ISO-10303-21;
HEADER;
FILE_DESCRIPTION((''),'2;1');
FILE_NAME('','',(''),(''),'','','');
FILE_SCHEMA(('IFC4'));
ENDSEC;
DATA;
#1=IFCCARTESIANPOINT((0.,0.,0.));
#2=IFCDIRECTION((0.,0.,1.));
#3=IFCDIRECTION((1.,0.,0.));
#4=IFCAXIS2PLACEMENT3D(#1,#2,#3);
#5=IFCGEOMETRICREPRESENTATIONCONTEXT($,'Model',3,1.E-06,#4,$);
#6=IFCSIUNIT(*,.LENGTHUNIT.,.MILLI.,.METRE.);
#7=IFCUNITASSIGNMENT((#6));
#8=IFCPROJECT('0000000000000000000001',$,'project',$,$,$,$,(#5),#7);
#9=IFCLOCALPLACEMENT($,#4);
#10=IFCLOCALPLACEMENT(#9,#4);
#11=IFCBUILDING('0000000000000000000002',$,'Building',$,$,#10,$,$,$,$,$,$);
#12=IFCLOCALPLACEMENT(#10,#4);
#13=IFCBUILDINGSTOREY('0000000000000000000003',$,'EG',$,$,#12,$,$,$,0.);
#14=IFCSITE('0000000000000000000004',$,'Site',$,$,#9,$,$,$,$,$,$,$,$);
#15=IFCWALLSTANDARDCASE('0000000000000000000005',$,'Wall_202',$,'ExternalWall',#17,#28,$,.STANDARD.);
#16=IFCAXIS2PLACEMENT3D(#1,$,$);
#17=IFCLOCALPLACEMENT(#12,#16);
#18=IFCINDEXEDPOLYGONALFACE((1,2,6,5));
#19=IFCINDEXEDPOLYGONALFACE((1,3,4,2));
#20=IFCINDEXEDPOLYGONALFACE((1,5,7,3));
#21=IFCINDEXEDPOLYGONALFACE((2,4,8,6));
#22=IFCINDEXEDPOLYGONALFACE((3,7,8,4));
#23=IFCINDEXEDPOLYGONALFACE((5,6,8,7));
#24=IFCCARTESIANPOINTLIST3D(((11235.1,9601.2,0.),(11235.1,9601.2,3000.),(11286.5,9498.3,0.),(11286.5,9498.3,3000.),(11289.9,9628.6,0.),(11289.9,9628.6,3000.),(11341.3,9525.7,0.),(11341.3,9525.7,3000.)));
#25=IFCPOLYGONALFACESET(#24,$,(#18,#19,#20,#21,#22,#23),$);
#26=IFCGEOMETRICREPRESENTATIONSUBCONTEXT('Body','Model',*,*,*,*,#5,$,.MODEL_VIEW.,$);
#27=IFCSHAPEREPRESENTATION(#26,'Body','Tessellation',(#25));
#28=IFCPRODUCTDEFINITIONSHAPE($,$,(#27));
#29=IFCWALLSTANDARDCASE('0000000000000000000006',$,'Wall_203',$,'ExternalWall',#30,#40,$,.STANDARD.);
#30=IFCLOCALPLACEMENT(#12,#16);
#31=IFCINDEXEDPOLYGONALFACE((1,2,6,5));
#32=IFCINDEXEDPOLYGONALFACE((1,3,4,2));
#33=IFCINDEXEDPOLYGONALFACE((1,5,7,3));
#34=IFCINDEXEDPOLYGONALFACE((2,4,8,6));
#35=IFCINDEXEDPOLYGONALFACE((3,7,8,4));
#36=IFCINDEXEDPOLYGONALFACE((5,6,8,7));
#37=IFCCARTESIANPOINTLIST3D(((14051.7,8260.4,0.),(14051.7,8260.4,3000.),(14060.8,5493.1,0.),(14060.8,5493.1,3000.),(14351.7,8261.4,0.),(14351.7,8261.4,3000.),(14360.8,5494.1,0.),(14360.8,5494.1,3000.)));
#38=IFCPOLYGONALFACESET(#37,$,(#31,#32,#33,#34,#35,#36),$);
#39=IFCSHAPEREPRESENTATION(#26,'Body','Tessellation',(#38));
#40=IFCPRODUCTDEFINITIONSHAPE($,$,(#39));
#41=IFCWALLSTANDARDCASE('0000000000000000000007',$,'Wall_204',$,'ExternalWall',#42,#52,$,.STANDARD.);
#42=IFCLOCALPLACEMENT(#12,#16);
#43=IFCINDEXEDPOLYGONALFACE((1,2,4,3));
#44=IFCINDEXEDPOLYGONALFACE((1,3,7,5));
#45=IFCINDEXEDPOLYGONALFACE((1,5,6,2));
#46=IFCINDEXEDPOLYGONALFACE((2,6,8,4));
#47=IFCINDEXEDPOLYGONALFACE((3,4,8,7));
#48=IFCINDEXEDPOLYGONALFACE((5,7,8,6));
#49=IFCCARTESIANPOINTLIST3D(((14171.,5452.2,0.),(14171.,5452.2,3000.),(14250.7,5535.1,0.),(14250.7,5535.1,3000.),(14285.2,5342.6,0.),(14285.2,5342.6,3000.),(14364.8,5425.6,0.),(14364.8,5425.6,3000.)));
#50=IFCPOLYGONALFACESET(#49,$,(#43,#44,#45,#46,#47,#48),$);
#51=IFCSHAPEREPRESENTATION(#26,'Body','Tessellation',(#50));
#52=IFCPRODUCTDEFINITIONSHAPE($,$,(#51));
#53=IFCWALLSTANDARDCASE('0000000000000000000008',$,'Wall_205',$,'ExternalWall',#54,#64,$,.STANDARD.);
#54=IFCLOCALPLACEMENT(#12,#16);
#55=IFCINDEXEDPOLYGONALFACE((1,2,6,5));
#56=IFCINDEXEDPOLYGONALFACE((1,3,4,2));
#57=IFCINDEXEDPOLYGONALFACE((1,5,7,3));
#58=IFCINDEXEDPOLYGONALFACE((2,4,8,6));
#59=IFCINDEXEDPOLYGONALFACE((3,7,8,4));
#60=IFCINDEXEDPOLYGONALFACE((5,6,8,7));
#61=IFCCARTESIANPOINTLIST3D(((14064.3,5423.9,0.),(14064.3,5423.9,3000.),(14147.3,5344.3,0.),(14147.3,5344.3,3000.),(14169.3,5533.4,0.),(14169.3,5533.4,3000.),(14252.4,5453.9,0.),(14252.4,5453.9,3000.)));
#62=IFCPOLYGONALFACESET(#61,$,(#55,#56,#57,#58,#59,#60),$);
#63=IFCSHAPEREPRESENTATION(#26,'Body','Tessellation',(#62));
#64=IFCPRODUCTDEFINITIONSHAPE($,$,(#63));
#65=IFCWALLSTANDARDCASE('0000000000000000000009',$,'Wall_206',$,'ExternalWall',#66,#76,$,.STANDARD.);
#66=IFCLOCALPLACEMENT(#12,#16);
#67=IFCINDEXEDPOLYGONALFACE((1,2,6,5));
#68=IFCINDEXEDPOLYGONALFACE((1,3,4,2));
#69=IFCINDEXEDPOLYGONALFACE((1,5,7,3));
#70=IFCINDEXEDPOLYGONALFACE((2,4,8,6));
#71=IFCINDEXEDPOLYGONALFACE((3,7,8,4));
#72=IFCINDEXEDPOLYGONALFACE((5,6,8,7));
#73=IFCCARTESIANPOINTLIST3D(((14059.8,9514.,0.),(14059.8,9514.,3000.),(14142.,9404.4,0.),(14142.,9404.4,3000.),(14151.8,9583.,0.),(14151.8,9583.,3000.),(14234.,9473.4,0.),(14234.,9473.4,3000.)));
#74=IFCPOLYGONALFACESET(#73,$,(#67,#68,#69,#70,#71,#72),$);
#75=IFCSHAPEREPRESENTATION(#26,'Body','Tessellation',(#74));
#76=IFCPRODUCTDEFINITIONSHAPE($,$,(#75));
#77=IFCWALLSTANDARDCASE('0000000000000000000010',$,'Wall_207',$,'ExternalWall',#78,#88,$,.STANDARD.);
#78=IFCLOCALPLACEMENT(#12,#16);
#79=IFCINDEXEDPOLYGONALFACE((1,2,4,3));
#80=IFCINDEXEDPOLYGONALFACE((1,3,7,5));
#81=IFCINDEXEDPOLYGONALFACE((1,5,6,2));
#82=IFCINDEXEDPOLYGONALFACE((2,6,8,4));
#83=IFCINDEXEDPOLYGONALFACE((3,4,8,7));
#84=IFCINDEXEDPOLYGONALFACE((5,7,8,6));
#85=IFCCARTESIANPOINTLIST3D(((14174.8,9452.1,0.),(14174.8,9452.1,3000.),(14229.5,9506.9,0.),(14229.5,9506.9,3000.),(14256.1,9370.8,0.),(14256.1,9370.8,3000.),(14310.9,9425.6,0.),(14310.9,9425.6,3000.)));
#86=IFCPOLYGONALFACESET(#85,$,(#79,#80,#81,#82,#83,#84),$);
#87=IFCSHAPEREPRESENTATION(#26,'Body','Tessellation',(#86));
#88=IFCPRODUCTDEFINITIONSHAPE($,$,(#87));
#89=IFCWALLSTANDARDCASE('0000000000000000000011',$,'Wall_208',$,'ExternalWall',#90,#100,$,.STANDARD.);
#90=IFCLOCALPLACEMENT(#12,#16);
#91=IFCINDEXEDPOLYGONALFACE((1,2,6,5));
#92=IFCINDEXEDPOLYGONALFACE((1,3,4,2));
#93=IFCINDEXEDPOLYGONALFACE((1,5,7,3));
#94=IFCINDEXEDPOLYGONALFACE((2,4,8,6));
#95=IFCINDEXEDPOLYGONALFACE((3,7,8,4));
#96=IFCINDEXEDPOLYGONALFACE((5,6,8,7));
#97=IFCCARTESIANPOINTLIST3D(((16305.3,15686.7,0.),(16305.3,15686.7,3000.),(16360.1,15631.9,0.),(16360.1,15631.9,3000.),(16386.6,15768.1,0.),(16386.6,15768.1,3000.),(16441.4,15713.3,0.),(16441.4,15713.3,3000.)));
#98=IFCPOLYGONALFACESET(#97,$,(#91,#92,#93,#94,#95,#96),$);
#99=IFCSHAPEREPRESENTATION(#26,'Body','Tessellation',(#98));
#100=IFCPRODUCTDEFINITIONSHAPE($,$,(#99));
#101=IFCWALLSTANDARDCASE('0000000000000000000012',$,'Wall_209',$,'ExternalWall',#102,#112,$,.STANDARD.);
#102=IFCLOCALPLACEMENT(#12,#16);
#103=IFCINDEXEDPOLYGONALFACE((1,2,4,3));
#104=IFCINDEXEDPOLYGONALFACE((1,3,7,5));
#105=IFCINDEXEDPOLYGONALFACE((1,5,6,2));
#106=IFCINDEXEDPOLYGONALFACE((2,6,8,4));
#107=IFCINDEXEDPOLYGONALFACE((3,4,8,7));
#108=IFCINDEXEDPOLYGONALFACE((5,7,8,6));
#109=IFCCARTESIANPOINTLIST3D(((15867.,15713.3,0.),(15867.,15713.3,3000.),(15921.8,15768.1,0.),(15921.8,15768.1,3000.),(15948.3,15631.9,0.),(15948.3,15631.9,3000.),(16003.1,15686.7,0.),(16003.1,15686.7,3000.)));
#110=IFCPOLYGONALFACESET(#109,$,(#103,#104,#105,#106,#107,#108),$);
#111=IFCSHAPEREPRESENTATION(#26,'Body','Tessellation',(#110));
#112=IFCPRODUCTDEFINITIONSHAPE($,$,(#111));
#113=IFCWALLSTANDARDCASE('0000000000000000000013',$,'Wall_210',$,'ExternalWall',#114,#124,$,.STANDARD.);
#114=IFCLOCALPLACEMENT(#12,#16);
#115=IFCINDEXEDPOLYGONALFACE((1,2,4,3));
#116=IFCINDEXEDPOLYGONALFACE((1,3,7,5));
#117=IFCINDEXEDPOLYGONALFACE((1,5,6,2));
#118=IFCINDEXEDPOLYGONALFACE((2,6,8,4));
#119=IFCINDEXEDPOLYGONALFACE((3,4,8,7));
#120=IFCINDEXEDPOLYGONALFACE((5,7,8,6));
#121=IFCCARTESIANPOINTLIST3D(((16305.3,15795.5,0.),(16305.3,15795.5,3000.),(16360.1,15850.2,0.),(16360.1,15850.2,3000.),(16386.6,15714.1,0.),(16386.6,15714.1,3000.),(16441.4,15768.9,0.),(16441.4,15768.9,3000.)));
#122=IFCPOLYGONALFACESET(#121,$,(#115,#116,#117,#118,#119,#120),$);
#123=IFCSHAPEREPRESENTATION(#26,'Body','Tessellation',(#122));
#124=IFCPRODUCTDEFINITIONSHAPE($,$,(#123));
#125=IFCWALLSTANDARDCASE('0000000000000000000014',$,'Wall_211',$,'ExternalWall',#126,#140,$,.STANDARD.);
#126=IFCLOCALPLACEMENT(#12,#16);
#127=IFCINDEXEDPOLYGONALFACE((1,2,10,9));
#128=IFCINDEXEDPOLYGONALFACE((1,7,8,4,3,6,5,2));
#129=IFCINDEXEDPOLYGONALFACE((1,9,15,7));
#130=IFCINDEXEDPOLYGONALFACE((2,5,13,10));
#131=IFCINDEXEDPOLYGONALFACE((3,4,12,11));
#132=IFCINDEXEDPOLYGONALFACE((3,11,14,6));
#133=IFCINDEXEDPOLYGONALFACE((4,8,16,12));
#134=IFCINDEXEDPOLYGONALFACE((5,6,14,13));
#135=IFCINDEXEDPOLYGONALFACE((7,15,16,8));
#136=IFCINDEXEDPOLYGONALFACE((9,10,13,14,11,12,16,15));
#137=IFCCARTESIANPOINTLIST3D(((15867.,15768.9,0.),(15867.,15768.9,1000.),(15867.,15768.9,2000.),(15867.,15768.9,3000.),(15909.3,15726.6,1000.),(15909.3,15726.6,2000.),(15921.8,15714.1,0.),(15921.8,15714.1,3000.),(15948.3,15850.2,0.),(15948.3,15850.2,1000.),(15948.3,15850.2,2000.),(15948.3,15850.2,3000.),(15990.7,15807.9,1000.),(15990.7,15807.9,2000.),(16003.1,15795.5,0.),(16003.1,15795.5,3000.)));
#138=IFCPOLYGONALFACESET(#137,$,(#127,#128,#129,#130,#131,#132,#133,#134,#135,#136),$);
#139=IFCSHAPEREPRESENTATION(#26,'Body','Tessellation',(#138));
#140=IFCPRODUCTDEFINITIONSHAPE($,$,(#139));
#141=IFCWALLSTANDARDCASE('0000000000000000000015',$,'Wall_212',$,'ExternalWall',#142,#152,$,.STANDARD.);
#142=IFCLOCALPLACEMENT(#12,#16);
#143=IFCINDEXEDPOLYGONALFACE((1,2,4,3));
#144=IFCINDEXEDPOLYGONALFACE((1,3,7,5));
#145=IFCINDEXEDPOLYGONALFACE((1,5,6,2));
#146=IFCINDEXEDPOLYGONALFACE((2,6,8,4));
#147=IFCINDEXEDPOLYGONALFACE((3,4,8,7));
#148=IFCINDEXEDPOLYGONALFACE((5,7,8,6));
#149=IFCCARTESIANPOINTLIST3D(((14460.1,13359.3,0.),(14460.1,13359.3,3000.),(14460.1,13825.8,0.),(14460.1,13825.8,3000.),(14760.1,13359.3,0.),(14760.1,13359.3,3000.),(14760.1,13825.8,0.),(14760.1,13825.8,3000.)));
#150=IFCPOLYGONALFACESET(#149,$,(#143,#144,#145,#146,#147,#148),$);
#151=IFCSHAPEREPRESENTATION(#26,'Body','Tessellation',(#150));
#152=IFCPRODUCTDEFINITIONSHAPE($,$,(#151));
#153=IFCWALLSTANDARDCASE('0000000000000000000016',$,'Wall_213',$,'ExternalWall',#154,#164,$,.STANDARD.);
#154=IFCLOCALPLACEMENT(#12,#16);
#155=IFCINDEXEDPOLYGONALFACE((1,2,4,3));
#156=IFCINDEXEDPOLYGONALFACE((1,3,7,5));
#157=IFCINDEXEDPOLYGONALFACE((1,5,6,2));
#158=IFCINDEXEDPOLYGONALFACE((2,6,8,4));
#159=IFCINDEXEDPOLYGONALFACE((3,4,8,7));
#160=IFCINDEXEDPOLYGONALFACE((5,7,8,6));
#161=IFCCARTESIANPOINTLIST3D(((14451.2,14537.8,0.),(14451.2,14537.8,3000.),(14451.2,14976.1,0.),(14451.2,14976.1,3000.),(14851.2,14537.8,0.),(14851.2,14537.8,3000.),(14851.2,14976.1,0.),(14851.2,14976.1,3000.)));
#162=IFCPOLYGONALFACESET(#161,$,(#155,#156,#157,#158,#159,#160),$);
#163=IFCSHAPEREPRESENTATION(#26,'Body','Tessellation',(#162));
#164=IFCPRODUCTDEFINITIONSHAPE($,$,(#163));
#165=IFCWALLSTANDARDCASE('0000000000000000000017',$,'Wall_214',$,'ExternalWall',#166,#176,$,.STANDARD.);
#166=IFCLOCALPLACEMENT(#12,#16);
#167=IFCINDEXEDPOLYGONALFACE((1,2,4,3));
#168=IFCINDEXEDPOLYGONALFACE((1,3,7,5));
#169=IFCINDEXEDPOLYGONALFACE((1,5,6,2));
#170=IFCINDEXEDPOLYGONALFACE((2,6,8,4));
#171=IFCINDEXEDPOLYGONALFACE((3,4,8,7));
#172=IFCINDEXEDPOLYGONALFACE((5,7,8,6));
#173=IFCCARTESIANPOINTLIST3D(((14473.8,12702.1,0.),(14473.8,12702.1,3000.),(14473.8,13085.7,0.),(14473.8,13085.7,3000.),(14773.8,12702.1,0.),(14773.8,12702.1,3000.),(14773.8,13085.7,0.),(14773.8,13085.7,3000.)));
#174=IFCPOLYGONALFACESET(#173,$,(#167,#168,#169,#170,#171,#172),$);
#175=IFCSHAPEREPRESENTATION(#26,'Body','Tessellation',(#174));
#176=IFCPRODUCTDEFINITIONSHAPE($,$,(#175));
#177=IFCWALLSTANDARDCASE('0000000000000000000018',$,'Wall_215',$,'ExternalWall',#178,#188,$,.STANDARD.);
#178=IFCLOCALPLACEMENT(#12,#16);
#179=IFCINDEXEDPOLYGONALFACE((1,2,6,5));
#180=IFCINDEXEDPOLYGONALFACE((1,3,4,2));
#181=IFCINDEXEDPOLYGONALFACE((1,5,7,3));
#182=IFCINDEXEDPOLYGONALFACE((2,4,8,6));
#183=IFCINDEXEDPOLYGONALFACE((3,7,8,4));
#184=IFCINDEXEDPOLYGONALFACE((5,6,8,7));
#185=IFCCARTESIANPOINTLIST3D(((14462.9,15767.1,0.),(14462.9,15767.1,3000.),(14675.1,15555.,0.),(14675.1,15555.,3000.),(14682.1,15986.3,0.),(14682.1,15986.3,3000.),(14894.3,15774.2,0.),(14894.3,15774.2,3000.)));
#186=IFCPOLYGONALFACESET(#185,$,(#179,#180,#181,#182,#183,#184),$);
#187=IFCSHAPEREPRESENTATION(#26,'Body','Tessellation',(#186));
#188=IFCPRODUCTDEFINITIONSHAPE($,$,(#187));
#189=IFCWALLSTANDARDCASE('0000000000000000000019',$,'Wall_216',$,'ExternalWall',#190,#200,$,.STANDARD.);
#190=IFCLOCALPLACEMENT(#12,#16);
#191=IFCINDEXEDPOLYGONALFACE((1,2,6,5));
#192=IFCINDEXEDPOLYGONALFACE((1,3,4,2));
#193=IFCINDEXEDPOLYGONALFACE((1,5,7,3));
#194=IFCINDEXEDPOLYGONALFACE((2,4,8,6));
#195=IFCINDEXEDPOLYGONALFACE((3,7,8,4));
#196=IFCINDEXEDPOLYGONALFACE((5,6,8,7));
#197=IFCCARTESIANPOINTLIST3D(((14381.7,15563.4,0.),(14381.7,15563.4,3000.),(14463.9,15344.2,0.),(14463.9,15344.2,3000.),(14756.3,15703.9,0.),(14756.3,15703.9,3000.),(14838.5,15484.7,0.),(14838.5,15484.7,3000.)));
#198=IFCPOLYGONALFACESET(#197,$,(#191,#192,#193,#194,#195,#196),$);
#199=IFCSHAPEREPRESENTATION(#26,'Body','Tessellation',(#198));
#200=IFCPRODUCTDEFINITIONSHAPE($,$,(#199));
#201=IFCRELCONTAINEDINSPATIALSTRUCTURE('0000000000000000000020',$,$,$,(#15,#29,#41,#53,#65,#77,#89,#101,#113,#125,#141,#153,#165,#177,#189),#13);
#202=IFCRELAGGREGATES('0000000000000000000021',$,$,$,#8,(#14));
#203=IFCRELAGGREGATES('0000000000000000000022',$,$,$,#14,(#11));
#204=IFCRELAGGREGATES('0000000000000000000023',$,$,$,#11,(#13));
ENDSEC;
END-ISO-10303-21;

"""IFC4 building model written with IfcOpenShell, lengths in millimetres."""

from ifc_helpers import new_model, si_unit, frame, origin_with_axes, place, context, subcontext, project, spatial, rectangle, extrude, element, save


model = new_model("IFC4")

# Units and contexts
model_context = context("Model", 3, precision=1e-06, world=origin_with_axes())
body_context = subcontext(model_context, "Body", "Model", "MODEL_VIEW")
ifc_project = project(units=[si_unit("LENGTHUNIT", "METRE", prefix="MILLI")], contexts=[model_context])

# Site, building, storey
site_placement = place(None, origin_with_axes())
site = spatial("IfcSite", under=ifc_project, at=site_placement, Name="Site")
building_placement = place(site_placement, origin_with_axes())
building = spatial("IfcBuilding", under=site, at=building_placement, Name="Building")
storey_placement = place(building_placement, origin_with_axes())
storey = spatial("IfcBuildingStorey", under=building, at=storey_placement, Name="EG", Elevation=0.0)

# Walls
wall_1_placement = place(storey_placement, origin_with_axes())
element("IfcWallStandardCase", 1, at=wall_1_placement, inside=storey, Name="Wall_202", ObjectType="ExternalWall", PredefinedType="STANDARD", context=body_context, shape_type="SweptSolid", body=[
    extrude(rectangle(XDim=61.3, YDim=115.0), frame((11288.2, 9563.4, 0.0), z_axis=(0.0, 0.0, 1.0), x_axis=(0.894427, 0.447214, 0.0)), (0.0, 0.0, 1.0), 3000.0),
])
wall_2_placement = place(storey_placement, origin_with_axes())
element("IfcWallStandardCase", 2, at=wall_2_placement, inside=storey, Name="Wall_203", ObjectType="ExternalWall", PredefinedType="STANDARD", context=body_context, shape_type="SweptSolid", body=[
    extrude(rectangle(XDim=2767.2, YDim=300.0), frame((14206.3, 6877.2, 0.0), z_axis=(0.0, 0.0, 1.0), x_axis=(0.0033, -0.999995, 0.0)), (0.0, 0.0, 1.0), 3000.0),
])
wall_3_placement = place(storey_placement, origin_with_axes())
element("IfcWallStandardCase", 3, at=wall_3_placement, inside=storey, Name="Wall_204", ObjectType="ExternalWall", PredefinedType="STANDARD", context=body_context, shape_type="SweptSolid", body=[
    extrude(rectangle(XDim=158.2, YDim=115.0), frame((14267.9, 5438.9, 0.0), z_axis=(0.0, 0.0, 1.0), x_axis=(0.721459, -0.692457, 0.0)), (0.0, 0.0, 1.0), 3000.0),
])
wall_4_placement = place(storey_placement, origin_with_axes())
element("IfcWallStandardCase", 4, at=wall_4_placement, inside=storey, Name="Wall_205", ObjectType="ExternalWall", PredefinedType="STANDARD", context=body_context, shape_type="SweptSolid", body=[
    extrude(rectangle(XDim=151.8, YDim=115.0), frame((14158.3, 5438.9, 0.0), z_axis=(0.0, 0.0, 1.0), x_axis=(-0.69198, -0.721917, 0.0)), (0.0, 0.0, 1.0), 3000.0),
])
wall_5_placement = place(storey_placement, origin_with_axes())
element("IfcWallStandardCase", 5, at=wall_5_placement, inside=storey, Name="Wall_206", ObjectType="ExternalWall", PredefinedType="STANDARD", context=body_context, shape_type="SweptSolid", body=[
    extrude(rectangle(XDim=137.0, YDim=115.0), frame((14146.9, 9493.7, 0.0), z_axis=(0.0, 0.0, 1.0), x_axis=(-0.6, 0.8, 0.0)), (0.0, 0.0, 1.0), 3000.0),
])
wall_6_placement = place(storey_placement, origin_with_axes())
element("IfcWallStandardCase", 6, at=wall_6_placement, inside=storey, Name="Wall_207", ObjectType="ExternalWall", PredefinedType="STANDARD", context=body_context, shape_type="SweptSolid", body=[
    extrude(rectangle(XDim=77.5, YDim=115.0), frame((14242.8, 9438.9, 0.0), z_axis=(0.0, 0.0, 1.0), x_axis=(0.707107, 0.707107, 0.0)), (0.0, 0.0, 1.0), 3000.0),
])
wall_7_placement = place(storey_placement, origin_with_axes())
element("IfcWallStandardCase", 7, at=wall_7_placement, inside=storey, Name="Wall_208", ObjectType="ExternalWall", PredefinedType="STANDARD", context=body_context, shape_type="SweptSolid", body=[
    extrude(rectangle(XDim=77.5, YDim=115.0), frame((16373.4, 15700.0, 0.0), z_axis=(0.0, 0.0, 1.0), x_axis=(0.707107, -0.707107, 0.0)), (0.0, 0.0, 1.0), 3000.0),
])
wall_8_placement = place(storey_placement, origin_with_axes())
element("IfcWallStandardCase", 8, at=wall_8_placement, inside=storey, Name="Wall_209", ObjectType="ExternalWall", PredefinedType="STANDARD", context=body_context, shape_type="SweptSolid", body=[
    extrude(rectangle(XDim=77.5, YDim=115.0), frame((15935.0, 15700.0, 0.0), z_axis=(0.0, 0.0, 1.0), x_axis=(-0.707107, -0.707107, 0.0)), (0.0, 0.0, 1.0), 3000.0),
])
wall_9_placement = place(storey_placement, origin_with_axes())
element("IfcWallStandardCase", 9, at=wall_9_placement, inside=storey, Name="Wall_210", ObjectType="ExternalWall", PredefinedType="STANDARD", context=body_context, shape_type="SweptSolid", body=[
    extrude(rectangle(XDim=77.5, YDim=115.0), frame((16373.4, 15782.2, 0.0), z_axis=(0.0, 0.0, 1.0), x_axis=(-0.707107, -0.707107, 0.0)), (0.0, 0.0, 1.0), 3000.0),
])

# Wall, opening
wall_10_placement = place(storey_placement, origin_with_axes())
wall_10 = element("IfcWallStandardCase", 10, at=wall_10_placement, inside=storey, Name="Wall_211", ObjectType="ExternalWall", PredefinedType="STANDARD", context=body_context, shape_type="SweptSolid", body=[
    extrude(rectangle(XDim=77.5, YDim=115.0), frame((15935.0, 15782.2, 0.0), z_axis=(0.0, 0.0, 1.0), x_axis=(-0.707107, 0.707107, 0.0)), (0.0, 0.0, 1.0), 3000.0),
])
opening_placement = place(wall_10_placement, origin_with_axes())
element("IfcOpeningElement", 11, at=opening_placement, inside=storey, cuts=wall_10, context=body_context, shape_type="SweptSolid", body=[
    extrude(rectangle(XDim=830.9, YDim=115.0), frame((15656.2, 16061.0, 1000.0), z_axis=(0.0, 0.0, 1.0), x_axis=(-0.707107, 0.707107, 0.0)), (0.0, 0.0, 1.0), 1000.0),
])

# Walls
wall_11_placement = place(storey_placement, origin_with_axes())
element("IfcWallStandardCase", 12, at=wall_11_placement, inside=storey, Name="Wall_212", ObjectType="ExternalWall", PredefinedType="STANDARD", context=body_context, shape_type="SweptSolid", body=[
    extrude(rectangle(XDim=466.6, YDim=300.0), frame((14610.1, 13592.6, 0.0), z_axis=(0.0, 0.0, 1.0), x_axis=(0.0, 1.0, 0.0)), (0.0, 0.0, 1.0), 3000.0),
])
wall_12_placement = place(storey_placement, origin_with_axes())
element("IfcWallStandardCase", 13, at=wall_12_placement, inside=storey, Name="Wall_213", ObjectType="ExternalWall", PredefinedType="STANDARD", context=body_context, shape_type="SweptSolid", body=[
    extrude(rectangle(XDim=438.4, YDim=400.0), frame((14651.2, 14756.9, 0.0), z_axis=(0.0, 0.0, 1.0), x_axis=(0.0, 1.0, 0.0)), (0.0, 0.0, 1.0), 3000.0),
])
wall_13_placement = place(storey_placement, origin_with_axes())
element("IfcWallStandardCase", 14, at=wall_13_placement, inside=storey, Name="Wall_214", ObjectType="ExternalWall", PredefinedType="STANDARD", context=body_context, shape_type="SweptSolid", body=[
    extrude(rectangle(XDim=383.6, YDim=300.0), frame((14623.8, 12893.9, 0.0), z_axis=(0.0, 0.0, 1.0), x_axis=(0.0, 1.0, 0.0)), (0.0, 0.0, 1.0), 3000.0),
])
wall_14_placement = place(storey_placement, origin_with_axes())
element("IfcWallStandardCase", 15, at=wall_14_placement, inside=storey, Name="Wall_215", ObjectType="ExternalWall", PredefinedType="STANDARD", context=body_context, shape_type="SweptSolid", body=[
    extrude(rectangle(XDim=310.0, YDim=300.0), frame((14678.6, 15770.6, 0.0), z_axis=(0.0, 0.0, 1.0), x_axis=(0.707107, 0.707107, 0.0)), (0.0, 0.0, 1.0), 3000.0),
])
wall_15_placement = place(storey_placement, origin_with_axes())
element("IfcWallStandardCase", 16, at=wall_15_placement, inside=storey, Name="Wall_216", ObjectType="ExternalWall", PredefinedType="STANDARD", context=body_context, shape_type="SweptSolid", body=[
    extrude(rectangle(XDim=234.1, YDim=400.0), frame((14610.1, 15524.1, 0.0), z_axis=(0.0, 0.0, 1.0), x_axis=(-0.351123, 0.936329, 0.0)), (0.0, 0.0, 1.0), 3000.0),
])

save(model, "model.ifc")
